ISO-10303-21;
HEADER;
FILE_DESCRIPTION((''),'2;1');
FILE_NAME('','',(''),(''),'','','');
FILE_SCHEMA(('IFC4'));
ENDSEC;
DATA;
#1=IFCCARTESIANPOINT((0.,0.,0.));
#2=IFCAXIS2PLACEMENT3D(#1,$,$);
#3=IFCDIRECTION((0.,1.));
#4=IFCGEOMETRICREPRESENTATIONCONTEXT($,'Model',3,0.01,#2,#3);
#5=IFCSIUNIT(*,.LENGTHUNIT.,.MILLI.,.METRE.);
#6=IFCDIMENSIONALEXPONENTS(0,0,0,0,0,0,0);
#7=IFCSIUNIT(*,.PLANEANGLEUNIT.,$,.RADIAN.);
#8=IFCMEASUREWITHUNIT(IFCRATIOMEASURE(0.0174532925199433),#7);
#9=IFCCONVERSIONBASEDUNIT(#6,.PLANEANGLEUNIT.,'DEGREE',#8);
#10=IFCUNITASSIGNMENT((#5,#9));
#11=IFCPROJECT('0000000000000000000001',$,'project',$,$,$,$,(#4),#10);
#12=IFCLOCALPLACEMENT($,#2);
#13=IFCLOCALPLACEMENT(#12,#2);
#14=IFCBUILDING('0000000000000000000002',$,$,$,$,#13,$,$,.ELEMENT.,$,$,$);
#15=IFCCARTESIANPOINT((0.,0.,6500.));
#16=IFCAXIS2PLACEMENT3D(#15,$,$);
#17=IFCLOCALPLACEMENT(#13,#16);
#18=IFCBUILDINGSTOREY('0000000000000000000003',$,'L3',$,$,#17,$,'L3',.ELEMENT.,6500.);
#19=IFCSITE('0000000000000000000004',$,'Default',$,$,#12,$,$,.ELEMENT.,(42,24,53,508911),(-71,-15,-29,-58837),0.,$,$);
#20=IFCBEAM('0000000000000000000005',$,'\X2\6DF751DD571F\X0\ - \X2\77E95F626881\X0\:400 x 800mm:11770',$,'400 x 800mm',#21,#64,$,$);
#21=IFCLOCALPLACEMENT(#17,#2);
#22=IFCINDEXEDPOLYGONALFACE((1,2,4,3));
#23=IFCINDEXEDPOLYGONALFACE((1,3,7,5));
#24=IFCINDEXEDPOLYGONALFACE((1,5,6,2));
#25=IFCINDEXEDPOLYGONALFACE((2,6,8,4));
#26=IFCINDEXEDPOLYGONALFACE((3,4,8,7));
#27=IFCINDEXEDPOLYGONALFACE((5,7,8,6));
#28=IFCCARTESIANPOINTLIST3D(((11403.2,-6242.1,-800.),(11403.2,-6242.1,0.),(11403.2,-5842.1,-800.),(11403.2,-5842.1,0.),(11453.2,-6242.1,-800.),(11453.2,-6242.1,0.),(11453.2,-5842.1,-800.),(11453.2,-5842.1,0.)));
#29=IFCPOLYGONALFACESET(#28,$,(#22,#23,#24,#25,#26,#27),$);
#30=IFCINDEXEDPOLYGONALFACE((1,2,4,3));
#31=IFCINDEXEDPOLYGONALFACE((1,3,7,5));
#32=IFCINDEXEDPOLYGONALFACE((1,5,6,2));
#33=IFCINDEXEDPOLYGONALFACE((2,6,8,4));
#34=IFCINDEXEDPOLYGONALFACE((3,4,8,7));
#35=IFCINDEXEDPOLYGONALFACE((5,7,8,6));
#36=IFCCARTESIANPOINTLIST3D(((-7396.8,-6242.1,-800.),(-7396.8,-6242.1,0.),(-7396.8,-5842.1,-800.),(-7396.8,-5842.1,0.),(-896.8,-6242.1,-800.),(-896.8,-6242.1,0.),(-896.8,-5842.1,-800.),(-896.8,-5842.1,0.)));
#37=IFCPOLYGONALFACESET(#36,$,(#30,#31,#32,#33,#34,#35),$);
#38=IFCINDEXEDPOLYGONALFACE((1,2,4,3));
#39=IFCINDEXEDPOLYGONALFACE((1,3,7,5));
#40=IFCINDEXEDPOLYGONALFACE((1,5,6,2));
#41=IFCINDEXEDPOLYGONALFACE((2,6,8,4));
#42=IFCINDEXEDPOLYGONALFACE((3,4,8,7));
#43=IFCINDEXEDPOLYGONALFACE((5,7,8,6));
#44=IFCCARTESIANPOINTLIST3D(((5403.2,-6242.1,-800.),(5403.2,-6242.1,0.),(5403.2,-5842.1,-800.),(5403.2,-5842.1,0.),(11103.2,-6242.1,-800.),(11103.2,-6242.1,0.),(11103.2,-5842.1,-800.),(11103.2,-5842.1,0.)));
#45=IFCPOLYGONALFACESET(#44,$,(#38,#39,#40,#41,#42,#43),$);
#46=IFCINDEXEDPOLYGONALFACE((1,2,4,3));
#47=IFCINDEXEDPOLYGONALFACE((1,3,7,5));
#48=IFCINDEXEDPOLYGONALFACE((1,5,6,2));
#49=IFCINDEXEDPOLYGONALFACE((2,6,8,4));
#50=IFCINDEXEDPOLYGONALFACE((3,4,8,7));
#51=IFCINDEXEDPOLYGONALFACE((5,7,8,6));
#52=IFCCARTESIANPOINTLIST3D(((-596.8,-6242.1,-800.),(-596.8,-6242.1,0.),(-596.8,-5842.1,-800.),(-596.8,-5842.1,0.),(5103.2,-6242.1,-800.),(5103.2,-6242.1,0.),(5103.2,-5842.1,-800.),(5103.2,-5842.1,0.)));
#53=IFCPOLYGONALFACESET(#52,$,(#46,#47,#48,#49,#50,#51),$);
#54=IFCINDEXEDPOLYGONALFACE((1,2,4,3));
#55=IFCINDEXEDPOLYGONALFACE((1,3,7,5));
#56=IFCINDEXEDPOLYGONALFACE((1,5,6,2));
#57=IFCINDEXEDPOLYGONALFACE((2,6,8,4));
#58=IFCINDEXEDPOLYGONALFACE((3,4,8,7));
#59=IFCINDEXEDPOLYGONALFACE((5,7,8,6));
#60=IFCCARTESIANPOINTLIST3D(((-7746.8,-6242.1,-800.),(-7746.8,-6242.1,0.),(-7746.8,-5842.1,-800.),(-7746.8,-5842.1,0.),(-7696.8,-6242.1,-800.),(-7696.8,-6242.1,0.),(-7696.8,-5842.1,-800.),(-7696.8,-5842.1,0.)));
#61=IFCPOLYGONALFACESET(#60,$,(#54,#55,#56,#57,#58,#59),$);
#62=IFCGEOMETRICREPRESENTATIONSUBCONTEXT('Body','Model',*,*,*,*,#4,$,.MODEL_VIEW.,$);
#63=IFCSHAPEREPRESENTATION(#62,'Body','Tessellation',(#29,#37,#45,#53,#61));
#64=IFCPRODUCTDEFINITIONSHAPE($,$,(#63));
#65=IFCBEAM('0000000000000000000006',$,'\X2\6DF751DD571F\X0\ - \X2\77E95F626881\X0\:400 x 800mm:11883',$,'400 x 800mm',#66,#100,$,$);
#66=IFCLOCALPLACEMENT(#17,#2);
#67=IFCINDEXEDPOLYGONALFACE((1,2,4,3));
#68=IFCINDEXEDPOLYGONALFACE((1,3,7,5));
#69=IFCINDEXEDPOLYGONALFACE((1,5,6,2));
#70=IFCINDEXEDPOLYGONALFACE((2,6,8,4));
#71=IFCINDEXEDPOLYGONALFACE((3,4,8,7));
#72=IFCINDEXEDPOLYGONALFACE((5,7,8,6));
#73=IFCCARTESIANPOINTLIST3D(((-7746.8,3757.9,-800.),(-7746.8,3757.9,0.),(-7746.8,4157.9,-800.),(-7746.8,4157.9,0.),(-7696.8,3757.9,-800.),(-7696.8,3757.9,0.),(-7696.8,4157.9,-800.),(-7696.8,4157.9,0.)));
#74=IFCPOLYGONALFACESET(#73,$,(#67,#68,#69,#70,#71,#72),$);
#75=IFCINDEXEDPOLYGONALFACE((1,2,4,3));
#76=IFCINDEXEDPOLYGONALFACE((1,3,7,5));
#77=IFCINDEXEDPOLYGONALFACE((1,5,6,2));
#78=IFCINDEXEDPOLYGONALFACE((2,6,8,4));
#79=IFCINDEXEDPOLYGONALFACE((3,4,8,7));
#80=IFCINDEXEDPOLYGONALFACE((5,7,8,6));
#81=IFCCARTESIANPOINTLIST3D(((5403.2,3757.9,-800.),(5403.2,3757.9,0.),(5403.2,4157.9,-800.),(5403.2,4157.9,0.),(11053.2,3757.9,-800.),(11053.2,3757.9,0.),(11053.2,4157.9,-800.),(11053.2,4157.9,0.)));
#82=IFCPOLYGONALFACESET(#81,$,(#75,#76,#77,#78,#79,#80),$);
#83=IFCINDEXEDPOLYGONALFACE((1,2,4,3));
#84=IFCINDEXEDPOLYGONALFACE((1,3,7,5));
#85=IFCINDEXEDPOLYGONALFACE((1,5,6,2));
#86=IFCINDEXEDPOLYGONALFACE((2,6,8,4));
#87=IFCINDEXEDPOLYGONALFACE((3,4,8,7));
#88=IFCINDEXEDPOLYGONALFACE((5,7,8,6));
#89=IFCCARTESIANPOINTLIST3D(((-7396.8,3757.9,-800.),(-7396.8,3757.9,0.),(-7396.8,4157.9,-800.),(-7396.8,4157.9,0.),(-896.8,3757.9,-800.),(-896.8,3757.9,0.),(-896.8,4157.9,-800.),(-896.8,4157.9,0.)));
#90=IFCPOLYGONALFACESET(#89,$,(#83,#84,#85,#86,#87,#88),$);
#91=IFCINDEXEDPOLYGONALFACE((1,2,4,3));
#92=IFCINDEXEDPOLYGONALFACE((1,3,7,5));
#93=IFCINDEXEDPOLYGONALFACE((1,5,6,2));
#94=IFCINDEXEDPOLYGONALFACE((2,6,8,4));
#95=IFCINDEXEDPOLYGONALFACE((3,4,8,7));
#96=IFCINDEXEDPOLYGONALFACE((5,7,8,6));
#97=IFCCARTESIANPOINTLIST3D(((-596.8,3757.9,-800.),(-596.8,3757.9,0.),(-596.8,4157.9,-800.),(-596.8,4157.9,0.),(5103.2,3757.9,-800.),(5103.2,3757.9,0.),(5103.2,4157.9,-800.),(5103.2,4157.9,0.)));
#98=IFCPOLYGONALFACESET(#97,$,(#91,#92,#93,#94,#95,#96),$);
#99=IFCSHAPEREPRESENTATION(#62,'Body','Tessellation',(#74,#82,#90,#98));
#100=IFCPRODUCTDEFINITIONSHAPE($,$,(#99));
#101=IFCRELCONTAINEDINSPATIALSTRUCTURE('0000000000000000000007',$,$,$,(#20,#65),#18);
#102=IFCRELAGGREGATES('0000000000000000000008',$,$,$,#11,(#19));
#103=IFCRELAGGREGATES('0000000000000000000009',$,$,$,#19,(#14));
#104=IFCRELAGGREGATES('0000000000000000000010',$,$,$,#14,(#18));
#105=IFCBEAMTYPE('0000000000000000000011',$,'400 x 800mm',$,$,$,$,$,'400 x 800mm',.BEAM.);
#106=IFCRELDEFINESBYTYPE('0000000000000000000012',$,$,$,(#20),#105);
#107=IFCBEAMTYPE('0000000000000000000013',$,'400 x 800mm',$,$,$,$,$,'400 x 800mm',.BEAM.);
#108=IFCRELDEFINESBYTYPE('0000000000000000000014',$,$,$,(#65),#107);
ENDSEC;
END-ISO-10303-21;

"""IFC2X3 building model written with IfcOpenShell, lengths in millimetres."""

from ifc_helpers import new_model, entity, si_unit, converted_unit, direction, frame, frame_2d, origin, origin_2d_with_axis, place, context, subcontext, project, spatial, rectangle, extrude, source, transform, mapped, type_object, type_shapes, element, save


model = new_model("IFC2X3")

# Units and contexts
model_context = context("Model", 3, precision=0.01, world=origin(), true_north=direction((0.0, 1.0)))
body_context = subcontext(model_context, "Body", "Model", "MODEL_VIEW")
ifc_project = project(units=[si_unit("LENGTHUNIT", "METRE", prefix="MILLI"), converted_unit("PLANEANGLEUNIT", "DEGREE", entity("IfcRatioMeasure", 0.0174532925199433), si_unit("PLANEANGLEUNIT", "RADIAN"), dimensions=[0, 0, 0, 0, 0, 0, 0])], contexts=[model_context])

# Site, building, storey
site_placement = place(None, origin())
site = spatial("IfcSite", under=ifc_project, at=site_placement, Name="Default", CompositionType="ELEMENT", RefLatitude=(42, 24, 53, 508911), RefLongitude=(-71, -15, -29, -58837), RefElevation=0.0)
building_placement = place(site_placement, origin())
building = spatial("IfcBuilding", under=site, at=building_placement, CompositionType="ELEMENT")
storey_placement = place(building_placement, frame((0.0, 0.0, 6500.0)))
storey = spatial("IfcBuildingStorey", under=building, at=storey_placement, Name="L3", LongName="L3", CompositionType="ELEMENT", Elevation=6500.0)

# Beams
beam_type_1 = type_object("IfcBeamType", Name="400 x 800mm", ElementType="400 x 800mm", PredefinedType="BEAM")
shared_shape_1 = source(origin(), body_context, "Body", "SweptSolid", [
    extrude(rectangle(XDim=50.0, YDim=400.0, at=frame_2d((0.0, 0.0), x_axis=(1.0, 0.0))), frame((11428.2, -6042.1, 5700.0), z_axis=(0.0, 0.0, 1.0), x_axis=(-1.0, 0.0, 0.0)), (0.0, 0.0, 1.0), 800.0),
    extrude(rectangle(XDim=6500.0, YDim=400.0, at=frame_2d((640.0, -40.0), x_axis=(1.0, 0.0))), frame((-4786.8, -6002.1, 5700.0)), (0.0, 0.0, 1.0), 800.0),
    extrude(rectangle(XDim=5700.0, YDim=400.0, at=frame_2d((560.0, 40.0), x_axis=(1.0, 0.0))), frame((8813.2, -6002.1, 5700.0), z_axis=(0.0, 0.0, 1.0), x_axis=(-1.0, 0.0, 0.0)), (0.0, 0.0, 1.0), 800.0),
    extrude(rectangle(XDim=5700.0, YDim=400.0, at=frame_2d((0.0, 0.0), x_axis=(1.0, 0.0))), frame((2253.2, -6042.1, 5700.0)), (0.0, 0.0, 1.0), 800.0),
    extrude(rectangle(XDim=50.0, YDim=400.0, at=frame_2d((0.0, 0.0), x_axis=(1.0, 0.0))), frame((-7721.8, -6042.1, 5700.0)), (0.0, 0.0, 1.0), 800.0),
])
type_shapes(beam_type_1, [shared_shape_1])
beam_1_placement = place(storey_placement, frame((0.0, 0.0, -6500.0)))
element("IfcBeam", 1, at=beam_1_placement, inside=storey, type_object=beam_type_1, Name="混凝土 - 矩形梁:400 x 800mm:11770", ObjectType="400 x 800mm", context=body_context, shape_type="MappedRepresentation", body=[
    mapped(shared_shape_1, transform((0.0, 0.0, 0.0), scale=1.0)),
])
beam_type_2 = type_object("IfcBeamType", Name="400 x 800mm", ElementType="400 x 800mm", PredefinedType="BEAM")
shared_shape_2 = source(origin(), body_context, "Body", "SweptSolid", [
    extrude(rectangle(XDim=50.0, YDim=400.0, at=frame_2d((0.0, 0.0), x_axis=(1.0, 0.0))), frame((-7721.8, 3957.9, 5700.0)), (0.0, 0.0, 1.0), 800.0),
    extrude(rectangle(XDim=5650.0, YDim=400.0, at=frame_2d((0.0, 0.0), x_axis=(1.0, 0.0))), frame((8228.2, 3957.9, 5700.0), z_axis=(0.0, 0.0, 1.0), x_axis=(-1.0, 0.0, 0.0)), (0.0, 0.0, 1.0), 800.0),
    extrude(rectangle(XDim=6500.0, YDim=400.0, at=frame_2d((640.0, 40.0), x_axis=(1.0, 0.0))), frame((-4786.8, 3917.9, 5700.0)), (0.0, 0.0, 1.0), 800.0),
    extrude(rectangle(XDim=5700.0, YDim=400.0, at=origin_2d_with_axis()), frame((2253.2, 3957.9, 5700.0), z_axis=(0.0, 0.0, 1.0), x_axis=(-1.0, 0.0, 0.0)), (0.0, 0.0, 1.0), 800.0),
])
type_shapes(beam_type_2, [shared_shape_2])
beam_2_placement = place(storey_placement, frame((0.0, 0.0, -6500.0)))
element("IfcBeam", 2, at=beam_2_placement, inside=storey, type_object=beam_type_2, Name="混凝土 - 矩形梁:400 x 800mm:11883", ObjectType="400 x 800mm", context=body_context, shape_type="MappedRepresentation", body=[
    mapped(shared_shape_2, transform((0.0, 0.0, 0.0), scale=1.0)),
])

save(model, "model.ifc")
